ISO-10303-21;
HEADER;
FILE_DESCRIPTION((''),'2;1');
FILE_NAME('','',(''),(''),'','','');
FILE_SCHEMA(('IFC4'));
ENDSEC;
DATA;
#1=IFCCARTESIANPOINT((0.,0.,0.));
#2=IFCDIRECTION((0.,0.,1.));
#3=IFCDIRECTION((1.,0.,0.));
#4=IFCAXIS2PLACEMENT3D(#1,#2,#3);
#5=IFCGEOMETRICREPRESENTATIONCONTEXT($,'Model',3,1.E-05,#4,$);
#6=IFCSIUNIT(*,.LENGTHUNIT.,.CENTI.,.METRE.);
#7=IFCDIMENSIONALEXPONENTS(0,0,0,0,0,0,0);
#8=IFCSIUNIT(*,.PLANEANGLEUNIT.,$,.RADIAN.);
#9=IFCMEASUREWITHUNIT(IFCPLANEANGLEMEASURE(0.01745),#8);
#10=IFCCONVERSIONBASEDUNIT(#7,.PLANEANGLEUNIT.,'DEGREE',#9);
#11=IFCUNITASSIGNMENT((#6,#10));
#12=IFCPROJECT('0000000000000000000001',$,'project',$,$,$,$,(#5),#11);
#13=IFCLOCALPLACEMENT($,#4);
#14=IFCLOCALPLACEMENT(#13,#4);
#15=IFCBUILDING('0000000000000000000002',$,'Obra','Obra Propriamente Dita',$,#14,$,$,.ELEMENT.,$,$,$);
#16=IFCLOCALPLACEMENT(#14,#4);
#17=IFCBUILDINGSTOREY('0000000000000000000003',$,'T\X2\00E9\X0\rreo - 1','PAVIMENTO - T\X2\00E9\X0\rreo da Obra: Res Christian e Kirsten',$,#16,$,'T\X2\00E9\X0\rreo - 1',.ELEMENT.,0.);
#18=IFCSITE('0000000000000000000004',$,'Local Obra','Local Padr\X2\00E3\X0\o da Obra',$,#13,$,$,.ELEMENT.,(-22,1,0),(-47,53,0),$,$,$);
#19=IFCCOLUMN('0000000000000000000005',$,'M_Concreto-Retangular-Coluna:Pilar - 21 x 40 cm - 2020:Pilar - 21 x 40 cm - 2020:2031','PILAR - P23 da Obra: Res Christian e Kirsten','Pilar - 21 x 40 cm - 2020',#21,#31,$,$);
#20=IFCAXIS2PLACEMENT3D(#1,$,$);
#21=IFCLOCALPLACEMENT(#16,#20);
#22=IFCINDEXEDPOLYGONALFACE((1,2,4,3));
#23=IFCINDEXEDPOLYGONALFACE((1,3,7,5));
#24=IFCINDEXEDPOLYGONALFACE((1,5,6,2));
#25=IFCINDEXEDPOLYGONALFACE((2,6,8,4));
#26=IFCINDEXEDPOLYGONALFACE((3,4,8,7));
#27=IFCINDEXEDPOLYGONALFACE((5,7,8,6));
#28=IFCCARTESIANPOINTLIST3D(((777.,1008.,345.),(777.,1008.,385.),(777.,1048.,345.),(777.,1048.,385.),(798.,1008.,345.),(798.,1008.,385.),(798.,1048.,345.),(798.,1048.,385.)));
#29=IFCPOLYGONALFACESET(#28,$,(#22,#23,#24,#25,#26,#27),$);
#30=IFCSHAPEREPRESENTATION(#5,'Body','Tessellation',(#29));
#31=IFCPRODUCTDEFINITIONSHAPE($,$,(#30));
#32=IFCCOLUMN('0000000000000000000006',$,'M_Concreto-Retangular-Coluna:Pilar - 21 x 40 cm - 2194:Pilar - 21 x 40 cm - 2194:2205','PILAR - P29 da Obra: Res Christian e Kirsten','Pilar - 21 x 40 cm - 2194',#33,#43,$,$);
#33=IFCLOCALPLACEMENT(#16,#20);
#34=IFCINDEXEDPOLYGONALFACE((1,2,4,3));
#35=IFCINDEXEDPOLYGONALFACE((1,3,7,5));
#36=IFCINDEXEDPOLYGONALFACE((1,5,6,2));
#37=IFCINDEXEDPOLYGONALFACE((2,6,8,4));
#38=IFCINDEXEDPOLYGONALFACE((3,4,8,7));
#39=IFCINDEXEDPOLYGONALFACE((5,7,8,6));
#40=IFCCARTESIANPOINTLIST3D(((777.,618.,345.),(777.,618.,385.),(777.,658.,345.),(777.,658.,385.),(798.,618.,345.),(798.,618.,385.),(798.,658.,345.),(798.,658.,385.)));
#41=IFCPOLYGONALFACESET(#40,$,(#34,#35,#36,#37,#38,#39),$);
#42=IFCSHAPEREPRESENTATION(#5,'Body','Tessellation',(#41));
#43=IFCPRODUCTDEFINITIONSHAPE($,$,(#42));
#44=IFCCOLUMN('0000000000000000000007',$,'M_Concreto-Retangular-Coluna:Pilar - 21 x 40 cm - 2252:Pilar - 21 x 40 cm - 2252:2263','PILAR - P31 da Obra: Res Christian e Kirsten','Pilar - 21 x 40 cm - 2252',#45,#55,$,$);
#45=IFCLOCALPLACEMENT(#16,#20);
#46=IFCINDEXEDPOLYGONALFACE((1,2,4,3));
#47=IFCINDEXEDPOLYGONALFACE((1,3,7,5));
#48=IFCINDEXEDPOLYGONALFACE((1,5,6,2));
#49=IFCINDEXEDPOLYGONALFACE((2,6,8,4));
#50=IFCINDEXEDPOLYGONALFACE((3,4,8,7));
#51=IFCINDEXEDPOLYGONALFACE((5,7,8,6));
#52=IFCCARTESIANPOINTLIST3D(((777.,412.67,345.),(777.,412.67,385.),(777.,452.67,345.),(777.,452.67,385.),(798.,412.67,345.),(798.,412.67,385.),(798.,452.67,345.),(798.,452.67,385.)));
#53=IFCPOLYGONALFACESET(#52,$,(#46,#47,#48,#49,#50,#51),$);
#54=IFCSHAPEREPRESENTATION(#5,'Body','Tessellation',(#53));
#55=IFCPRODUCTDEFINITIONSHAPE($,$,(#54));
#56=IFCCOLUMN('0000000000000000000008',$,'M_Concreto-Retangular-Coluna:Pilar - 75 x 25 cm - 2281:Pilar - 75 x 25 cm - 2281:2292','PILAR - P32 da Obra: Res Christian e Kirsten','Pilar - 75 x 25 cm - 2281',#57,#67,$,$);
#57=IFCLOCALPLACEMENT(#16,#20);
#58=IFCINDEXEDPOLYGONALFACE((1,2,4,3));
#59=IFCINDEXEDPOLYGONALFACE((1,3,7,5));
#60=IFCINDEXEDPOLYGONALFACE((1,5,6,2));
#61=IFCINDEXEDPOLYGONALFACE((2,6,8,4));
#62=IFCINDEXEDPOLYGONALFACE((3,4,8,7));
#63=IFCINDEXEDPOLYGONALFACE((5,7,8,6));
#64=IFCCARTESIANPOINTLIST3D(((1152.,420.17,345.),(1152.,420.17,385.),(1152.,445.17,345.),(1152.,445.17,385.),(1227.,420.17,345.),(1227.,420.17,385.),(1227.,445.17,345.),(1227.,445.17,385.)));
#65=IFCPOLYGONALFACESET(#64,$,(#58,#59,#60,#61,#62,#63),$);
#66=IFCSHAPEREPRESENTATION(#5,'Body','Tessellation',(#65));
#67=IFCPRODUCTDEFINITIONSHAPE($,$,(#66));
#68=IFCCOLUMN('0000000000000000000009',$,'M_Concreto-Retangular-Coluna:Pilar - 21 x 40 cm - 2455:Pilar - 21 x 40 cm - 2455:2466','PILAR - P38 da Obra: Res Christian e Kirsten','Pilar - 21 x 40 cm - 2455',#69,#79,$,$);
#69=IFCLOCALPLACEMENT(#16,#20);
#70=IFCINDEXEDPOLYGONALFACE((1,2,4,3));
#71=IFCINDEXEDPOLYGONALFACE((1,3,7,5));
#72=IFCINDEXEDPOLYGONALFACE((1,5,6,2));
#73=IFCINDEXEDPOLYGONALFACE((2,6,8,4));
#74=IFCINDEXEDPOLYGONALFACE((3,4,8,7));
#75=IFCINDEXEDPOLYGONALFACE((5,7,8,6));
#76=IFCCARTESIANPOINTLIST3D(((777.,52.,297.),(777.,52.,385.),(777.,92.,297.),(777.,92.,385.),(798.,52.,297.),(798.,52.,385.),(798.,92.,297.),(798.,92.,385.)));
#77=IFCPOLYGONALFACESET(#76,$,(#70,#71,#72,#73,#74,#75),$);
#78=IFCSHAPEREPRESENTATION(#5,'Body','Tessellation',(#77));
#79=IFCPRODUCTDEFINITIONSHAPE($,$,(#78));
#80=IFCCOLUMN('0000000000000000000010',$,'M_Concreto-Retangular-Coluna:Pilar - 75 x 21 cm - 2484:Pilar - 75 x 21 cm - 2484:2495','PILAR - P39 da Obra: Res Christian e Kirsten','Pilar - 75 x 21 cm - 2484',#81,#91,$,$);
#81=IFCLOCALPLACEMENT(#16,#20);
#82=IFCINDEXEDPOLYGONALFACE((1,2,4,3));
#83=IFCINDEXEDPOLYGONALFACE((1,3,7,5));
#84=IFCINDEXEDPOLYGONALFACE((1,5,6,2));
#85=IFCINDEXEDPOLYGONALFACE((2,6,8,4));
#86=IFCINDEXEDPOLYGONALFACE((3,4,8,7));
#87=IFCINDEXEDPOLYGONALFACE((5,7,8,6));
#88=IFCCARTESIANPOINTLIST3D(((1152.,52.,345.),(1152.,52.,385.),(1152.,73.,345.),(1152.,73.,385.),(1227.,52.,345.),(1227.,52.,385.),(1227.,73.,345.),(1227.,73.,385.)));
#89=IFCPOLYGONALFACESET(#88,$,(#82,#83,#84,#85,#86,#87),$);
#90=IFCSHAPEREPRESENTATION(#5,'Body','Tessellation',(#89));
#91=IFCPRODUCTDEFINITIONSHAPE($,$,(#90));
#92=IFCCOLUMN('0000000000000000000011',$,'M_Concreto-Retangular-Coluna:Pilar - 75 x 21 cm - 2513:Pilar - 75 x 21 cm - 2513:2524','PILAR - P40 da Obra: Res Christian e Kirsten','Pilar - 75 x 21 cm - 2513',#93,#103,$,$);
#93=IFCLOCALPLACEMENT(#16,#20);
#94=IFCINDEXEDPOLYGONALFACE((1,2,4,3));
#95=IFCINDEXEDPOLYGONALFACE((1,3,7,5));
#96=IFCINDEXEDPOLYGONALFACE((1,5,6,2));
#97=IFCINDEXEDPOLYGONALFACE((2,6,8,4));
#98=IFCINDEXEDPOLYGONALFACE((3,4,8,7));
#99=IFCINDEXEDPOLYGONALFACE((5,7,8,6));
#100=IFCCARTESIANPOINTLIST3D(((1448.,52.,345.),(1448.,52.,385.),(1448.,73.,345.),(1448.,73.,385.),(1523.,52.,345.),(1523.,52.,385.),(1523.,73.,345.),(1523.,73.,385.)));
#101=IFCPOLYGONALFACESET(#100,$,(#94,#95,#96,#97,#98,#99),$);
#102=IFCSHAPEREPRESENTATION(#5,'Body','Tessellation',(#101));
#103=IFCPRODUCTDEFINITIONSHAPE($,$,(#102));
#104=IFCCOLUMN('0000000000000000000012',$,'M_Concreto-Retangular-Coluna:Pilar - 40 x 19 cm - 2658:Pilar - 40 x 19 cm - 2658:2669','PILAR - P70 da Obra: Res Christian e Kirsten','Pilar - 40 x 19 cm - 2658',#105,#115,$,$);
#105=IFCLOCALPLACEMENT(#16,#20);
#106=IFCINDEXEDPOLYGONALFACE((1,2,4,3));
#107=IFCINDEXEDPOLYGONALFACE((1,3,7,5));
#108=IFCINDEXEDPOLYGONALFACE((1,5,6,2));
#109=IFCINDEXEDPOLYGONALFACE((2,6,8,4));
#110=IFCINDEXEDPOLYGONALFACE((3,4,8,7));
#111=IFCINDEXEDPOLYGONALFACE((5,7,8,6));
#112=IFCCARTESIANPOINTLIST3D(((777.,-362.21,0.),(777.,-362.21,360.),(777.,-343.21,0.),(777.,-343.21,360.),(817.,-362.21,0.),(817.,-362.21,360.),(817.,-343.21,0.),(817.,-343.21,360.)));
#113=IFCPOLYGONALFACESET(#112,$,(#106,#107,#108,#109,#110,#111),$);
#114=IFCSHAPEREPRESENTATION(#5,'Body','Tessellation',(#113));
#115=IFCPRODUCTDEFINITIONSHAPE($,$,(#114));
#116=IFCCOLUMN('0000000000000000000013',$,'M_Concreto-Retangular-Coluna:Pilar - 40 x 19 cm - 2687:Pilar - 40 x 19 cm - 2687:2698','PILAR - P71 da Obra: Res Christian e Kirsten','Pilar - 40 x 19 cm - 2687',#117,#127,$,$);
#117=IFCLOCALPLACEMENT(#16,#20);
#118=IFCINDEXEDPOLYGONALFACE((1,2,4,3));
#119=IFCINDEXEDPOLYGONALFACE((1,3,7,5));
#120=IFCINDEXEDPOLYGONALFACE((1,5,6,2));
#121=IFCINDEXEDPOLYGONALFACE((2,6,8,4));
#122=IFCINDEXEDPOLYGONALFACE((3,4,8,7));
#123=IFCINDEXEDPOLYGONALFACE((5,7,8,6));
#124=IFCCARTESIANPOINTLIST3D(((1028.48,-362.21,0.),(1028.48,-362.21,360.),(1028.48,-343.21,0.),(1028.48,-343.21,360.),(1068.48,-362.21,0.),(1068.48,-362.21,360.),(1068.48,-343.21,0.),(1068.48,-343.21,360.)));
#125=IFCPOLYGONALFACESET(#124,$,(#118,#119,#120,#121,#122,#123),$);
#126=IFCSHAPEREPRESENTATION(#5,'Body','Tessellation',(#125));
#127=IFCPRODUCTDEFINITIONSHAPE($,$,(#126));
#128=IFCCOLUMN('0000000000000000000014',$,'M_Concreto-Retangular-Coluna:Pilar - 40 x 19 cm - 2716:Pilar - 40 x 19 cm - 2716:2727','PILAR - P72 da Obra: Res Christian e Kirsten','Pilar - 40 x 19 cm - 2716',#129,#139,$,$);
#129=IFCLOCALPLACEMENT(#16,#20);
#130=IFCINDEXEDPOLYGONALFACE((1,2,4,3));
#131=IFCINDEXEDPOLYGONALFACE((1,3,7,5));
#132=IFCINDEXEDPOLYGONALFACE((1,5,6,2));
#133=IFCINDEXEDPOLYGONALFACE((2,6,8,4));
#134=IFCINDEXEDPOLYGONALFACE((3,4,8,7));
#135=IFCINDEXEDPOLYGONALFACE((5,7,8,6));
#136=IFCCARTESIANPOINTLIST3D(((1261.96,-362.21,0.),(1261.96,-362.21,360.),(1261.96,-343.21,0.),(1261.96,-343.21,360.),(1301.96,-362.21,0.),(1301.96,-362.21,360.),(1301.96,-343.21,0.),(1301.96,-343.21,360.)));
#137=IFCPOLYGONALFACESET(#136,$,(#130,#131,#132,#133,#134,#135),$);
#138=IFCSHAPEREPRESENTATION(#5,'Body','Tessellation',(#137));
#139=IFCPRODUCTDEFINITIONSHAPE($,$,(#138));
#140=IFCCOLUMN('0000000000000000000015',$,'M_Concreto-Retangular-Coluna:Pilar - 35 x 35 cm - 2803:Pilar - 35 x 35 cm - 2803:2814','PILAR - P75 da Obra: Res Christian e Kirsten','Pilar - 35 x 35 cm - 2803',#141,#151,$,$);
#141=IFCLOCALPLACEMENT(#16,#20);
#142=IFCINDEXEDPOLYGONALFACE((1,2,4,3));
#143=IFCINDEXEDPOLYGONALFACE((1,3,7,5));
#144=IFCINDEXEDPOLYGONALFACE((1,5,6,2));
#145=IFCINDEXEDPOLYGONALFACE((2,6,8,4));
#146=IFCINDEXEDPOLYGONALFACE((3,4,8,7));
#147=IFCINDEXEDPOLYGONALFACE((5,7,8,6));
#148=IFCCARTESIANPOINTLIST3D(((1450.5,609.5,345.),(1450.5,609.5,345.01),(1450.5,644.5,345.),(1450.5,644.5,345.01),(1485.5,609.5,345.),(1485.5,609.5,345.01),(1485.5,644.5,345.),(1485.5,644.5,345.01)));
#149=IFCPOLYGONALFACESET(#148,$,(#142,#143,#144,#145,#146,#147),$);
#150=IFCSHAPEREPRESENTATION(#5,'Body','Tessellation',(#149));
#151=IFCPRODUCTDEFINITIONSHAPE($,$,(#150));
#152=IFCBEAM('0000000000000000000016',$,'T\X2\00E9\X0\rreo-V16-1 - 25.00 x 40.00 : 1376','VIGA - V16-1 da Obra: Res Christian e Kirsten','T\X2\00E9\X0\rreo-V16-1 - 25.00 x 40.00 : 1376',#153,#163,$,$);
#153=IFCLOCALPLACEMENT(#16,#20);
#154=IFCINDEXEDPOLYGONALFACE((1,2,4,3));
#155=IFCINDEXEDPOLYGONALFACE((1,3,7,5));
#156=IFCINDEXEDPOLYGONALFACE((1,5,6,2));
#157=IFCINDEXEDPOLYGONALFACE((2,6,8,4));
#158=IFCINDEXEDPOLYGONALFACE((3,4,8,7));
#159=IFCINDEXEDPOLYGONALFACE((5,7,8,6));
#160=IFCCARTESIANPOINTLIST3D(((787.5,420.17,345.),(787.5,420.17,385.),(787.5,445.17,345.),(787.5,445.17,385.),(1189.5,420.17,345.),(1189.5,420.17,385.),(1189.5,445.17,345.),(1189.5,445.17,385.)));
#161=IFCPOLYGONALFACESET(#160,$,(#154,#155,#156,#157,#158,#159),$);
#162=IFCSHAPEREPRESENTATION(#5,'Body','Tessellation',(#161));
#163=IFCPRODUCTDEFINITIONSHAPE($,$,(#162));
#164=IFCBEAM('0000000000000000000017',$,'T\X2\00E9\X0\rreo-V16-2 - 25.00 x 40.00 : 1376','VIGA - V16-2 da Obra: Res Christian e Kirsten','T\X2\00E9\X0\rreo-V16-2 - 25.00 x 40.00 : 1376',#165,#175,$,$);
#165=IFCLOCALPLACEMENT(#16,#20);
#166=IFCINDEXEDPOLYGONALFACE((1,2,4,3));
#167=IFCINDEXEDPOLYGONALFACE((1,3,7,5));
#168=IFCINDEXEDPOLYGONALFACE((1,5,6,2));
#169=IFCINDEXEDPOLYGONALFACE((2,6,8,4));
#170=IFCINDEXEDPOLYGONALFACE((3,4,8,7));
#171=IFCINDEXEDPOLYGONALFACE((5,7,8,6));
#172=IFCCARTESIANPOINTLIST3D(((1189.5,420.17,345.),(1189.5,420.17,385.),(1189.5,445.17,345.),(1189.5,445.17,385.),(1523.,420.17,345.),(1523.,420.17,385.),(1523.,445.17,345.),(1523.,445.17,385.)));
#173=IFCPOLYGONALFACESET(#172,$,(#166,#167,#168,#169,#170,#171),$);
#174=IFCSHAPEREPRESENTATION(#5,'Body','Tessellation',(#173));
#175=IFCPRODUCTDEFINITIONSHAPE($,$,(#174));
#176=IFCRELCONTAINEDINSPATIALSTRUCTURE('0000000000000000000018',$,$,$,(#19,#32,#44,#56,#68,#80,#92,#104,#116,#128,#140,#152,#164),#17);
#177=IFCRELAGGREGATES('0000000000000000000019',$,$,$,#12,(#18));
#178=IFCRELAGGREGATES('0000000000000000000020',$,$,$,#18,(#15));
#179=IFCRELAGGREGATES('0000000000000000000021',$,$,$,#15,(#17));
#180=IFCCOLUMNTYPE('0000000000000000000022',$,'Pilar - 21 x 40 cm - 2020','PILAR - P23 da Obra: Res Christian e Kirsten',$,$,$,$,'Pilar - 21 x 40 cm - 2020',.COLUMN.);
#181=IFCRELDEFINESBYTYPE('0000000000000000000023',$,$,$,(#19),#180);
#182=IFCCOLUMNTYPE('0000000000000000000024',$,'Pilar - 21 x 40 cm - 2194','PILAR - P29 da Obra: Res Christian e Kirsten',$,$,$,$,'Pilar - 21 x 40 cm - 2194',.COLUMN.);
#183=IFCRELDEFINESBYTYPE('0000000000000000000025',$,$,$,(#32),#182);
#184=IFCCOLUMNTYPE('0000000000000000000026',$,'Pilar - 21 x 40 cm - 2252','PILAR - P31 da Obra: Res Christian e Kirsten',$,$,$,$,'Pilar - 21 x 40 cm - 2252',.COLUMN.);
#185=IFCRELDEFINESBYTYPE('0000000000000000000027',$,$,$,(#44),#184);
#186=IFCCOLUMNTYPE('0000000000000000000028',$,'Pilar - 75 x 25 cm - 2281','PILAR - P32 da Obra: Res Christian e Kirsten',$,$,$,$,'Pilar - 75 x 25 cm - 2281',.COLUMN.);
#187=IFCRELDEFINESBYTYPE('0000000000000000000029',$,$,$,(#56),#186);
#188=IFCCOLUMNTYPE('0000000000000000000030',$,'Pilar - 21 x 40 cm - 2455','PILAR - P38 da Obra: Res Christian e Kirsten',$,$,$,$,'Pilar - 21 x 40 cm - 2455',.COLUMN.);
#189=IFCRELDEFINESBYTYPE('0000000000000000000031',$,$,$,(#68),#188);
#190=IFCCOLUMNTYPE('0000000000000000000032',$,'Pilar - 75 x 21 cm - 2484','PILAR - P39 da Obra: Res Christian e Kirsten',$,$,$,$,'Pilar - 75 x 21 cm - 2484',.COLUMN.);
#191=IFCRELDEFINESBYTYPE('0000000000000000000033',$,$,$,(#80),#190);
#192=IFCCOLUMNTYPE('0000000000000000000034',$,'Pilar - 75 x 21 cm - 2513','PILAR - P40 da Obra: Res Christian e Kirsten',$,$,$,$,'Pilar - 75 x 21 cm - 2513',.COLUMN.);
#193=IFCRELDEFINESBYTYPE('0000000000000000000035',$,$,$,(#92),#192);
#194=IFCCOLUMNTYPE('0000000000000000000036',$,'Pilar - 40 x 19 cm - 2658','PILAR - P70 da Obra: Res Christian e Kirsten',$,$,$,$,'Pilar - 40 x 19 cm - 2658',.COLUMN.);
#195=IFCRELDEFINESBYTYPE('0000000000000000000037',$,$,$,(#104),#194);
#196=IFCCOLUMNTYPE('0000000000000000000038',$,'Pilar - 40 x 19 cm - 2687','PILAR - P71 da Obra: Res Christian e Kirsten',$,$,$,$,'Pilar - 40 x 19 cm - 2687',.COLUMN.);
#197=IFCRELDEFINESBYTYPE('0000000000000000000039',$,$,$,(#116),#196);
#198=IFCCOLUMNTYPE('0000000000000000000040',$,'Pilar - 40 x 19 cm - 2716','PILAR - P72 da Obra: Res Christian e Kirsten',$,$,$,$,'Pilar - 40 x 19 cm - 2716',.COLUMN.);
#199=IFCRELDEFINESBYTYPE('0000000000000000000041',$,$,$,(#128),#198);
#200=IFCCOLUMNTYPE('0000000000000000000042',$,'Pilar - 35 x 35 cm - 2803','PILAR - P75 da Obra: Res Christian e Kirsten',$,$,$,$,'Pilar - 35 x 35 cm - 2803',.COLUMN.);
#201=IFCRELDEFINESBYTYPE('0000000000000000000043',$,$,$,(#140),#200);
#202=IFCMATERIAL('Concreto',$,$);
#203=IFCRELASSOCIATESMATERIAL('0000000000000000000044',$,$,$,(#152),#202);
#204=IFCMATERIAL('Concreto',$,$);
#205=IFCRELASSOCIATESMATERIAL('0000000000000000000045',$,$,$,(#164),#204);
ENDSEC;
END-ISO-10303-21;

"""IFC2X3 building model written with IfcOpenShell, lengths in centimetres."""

from ifc_helpers import new_model, entity, si_unit, converted_unit, frame, origin, origin_with_axes, origin_2d_with_axis, place, context, project, spatial, polyline, rectangle, outline, extrude, source, transform, mapped, material, type_object, type_shapes, element, save


model = new_model("IFC2X3")

# Units and contexts
model_context = context("Model", 3, precision=1e-05, world=origin_with_axes())
ifc_project = project(units=[si_unit("LENGTHUNIT", "METRE", prefix="CENTI"), converted_unit("PLANEANGLEUNIT", "DEGREE", entity("IfcPlaneAngleMeasure", 0.01745), si_unit("PLANEANGLEUNIT", "RADIAN"), dimensions=[0, 0, 0, 0, 0, 0, 0])], contexts=[model_context])

# Site, building, storey
site_placement = place(None, origin_with_axes())
site = spatial("IfcSite", under=ifc_project, at=site_placement, Name="Local Obra", Description="Local Padrão da Obra", CompositionType="ELEMENT", RefLatitude=(-22, 1, 0), RefLongitude=(-47, 53, 0))
building_placement = place(site_placement, origin_with_axes())
building = spatial("IfcBuilding", under=site, at=building_placement, Name="Obra", Description="Obra Propriamente Dita", CompositionType="ELEMENT")
storey_placement = place(building_placement, origin_with_axes())
storey = spatial("IfcBuildingStorey", under=building, at=storey_placement, Name="Térreo - 1", Description="PAVIMENTO - Térreo da Obra: Res Christian e Kirsten", LongName="Térreo - 1", CompositionType="ELEMENT", Elevation=0.0)

# Columns
column_type_1 = type_object("IfcColumnType", Name="Pilar - 21 x 40 cm - 2020", Description="PILAR - P23 da Obra: Res Christian e Kirsten", ElementType="Pilar - 21 x 40 cm - 2020", PredefinedType="COLUMN")
shared_shape_1 = source(origin(), model_context, "Body", "SweptSolid", [
    extrude(rectangle(XDim=21.0, YDim=40.0, at=origin_2d_with_axis()), origin(), (0.0, 0.0, 1.0), 40.0),
])
type_shapes(column_type_1, [shared_shape_1])
column_1_placement = place(storey_placement, frame((787.5, 1028.0, 345.0), z_axis=(0.0, 0.0, 1.0), x_axis=(1.0, 0.0, 0.0)))
element("IfcColumn", 1, at=column_1_placement, inside=storey, type_object=column_type_1, Name="M_Concreto-Retangular-Coluna:Pilar - 21 x 40 cm - 2020:Pilar - 21 x 40 cm - 2020:2031", Description="PILAR - P23 da Obra: Res Christian e Kirsten", ObjectType="Pilar - 21 x 40 cm - 2020", context=model_context, shape_type="MappedRepresentation", body=[
    mapped(shared_shape_1, transform((0.0, 0.0, 0.0), scale=1.0)),
])
column_type_2 = type_object("IfcColumnType", Name="Pilar - 21 x 40 cm - 2194", Description="PILAR - P29 da Obra: Res Christian e Kirsten", ElementType="Pilar - 21 x 40 cm - 2194", PredefinedType="COLUMN")
shared_shape_2 = source(origin(), model_context, "Body", "SweptSolid", [
    extrude(rectangle(XDim=21.0, YDim=40.0, at=origin_2d_with_axis()), origin(), (0.0, 0.0, 1.0), 40.0),
])
type_shapes(column_type_2, [shared_shape_2])
column_2_placement = place(storey_placement, frame((787.5, 638.0, 345.0), z_axis=(0.0, 0.0, 1.0), x_axis=(1.0, 0.0, 0.0)))
element("IfcColumn", 2, at=column_2_placement, inside=storey, type_object=column_type_2, Name="M_Concreto-Retangular-Coluna:Pilar - 21 x 40 cm - 2194:Pilar - 21 x 40 cm - 2194:2205", Description="PILAR - P29 da Obra: Res Christian e Kirsten", ObjectType="Pilar - 21 x 40 cm - 2194", context=model_context, shape_type="MappedRepresentation", body=[
    mapped(shared_shape_2, transform((0.0, 0.0, 0.0), scale=1.0)),
])
column_type_3 = type_object("IfcColumnType", Name="Pilar - 21 x 40 cm - 2252", Description="PILAR - P31 da Obra: Res Christian e Kirsten", ElementType="Pilar - 21 x 40 cm - 2252", PredefinedType="COLUMN")
shared_shape_3 = source(origin(), model_context, "Body", "SweptSolid", [
    extrude(rectangle(XDim=21.0, YDim=40.0, at=origin_2d_with_axis()), origin(), (0.0, 0.0, 1.0), 40.0),
])
type_shapes(column_type_3, [shared_shape_3])
column_3_placement = place(storey_placement, frame((787.5, 432.67, 345.0), z_axis=(0.0, 0.0, 1.0), x_axis=(1.0, 0.0, 0.0)))
element("IfcColumn", 3, at=column_3_placement, inside=storey, type_object=column_type_3, Name="M_Concreto-Retangular-Coluna:Pilar - 21 x 40 cm - 2252:Pilar - 21 x 40 cm - 2252:2263", Description="PILAR - P31 da Obra: Res Christian e Kirsten", ObjectType="Pilar - 21 x 40 cm - 2252", context=model_context, shape_type="MappedRepresentation", body=[
    mapped(shared_shape_3, transform((0.0, 0.0, 0.0), scale=1.0)),
])
column_type_4 = type_object("IfcColumnType", Name="Pilar - 75 x 25 cm - 2281", Description="PILAR - P32 da Obra: Res Christian e Kirsten", ElementType="Pilar - 75 x 25 cm - 2281", PredefinedType="COLUMN")
shared_shape_4 = source(origin(), model_context, "Body", "SweptSolid", [
    extrude(rectangle(XDim=75.0, YDim=25.0, at=origin_2d_with_axis()), origin(), (0.0, 0.0, 1.0), 40.0),
])
type_shapes(column_type_4, [shared_shape_4])
column_4_placement = place(storey_placement, frame((1189.5, 432.67, 345.0), z_axis=(0.0, 0.0, 1.0), x_axis=(1.0, 0.0, 0.0)))
element("IfcColumn", 4, at=column_4_placement, inside=storey, type_object=column_type_4, Name="M_Concreto-Retangular-Coluna:Pilar - 75 x 25 cm - 2281:Pilar - 75 x 25 cm - 2281:2292", Description="PILAR - P32 da Obra: Res Christian e Kirsten", ObjectType="Pilar - 75 x 25 cm - 2281", context=model_context, shape_type="MappedRepresentation", body=[
    mapped(shared_shape_4, transform((0.0, 0.0, 0.0), scale=1.0)),
])
column_type_5 = type_object("IfcColumnType", Name="Pilar - 21 x 40 cm - 2455", Description="PILAR - P38 da Obra: Res Christian e Kirsten", ElementType="Pilar - 21 x 40 cm - 2455", PredefinedType="COLUMN")
shared_shape_5 = source(origin(), model_context, "Body", "SweptSolid", [
    extrude(rectangle(XDim=21.0, YDim=40.0, at=origin_2d_with_axis()), origin(), (0.0, 0.0, 1.0), 88.0),
])
type_shapes(column_type_5, [shared_shape_5])
column_5_placement = place(storey_placement, frame((787.5, 72.0, 297.0), z_axis=(0.0, 0.0, 1.0), x_axis=(1.0, 0.0, 0.0)))
element("IfcColumn", 5, at=column_5_placement, inside=storey, type_object=column_type_5, Name="M_Concreto-Retangular-Coluna:Pilar - 21 x 40 cm - 2455:Pilar - 21 x 40 cm - 2455:2466", Description="PILAR - P38 da Obra: Res Christian e Kirsten", ObjectType="Pilar - 21 x 40 cm - 2455", context=model_context, shape_type="MappedRepresentation", body=[
    mapped(shared_shape_5, transform((0.0, 0.0, 0.0), scale=1.0)),
])
column_type_6 = type_object("IfcColumnType", Name="Pilar - 75 x 21 cm - 2484", Description="PILAR - P39 da Obra: Res Christian e Kirsten", ElementType="Pilar - 75 x 21 cm - 2484", PredefinedType="COLUMN")
shared_shape_6 = source(origin(), model_context, "Body", "SweptSolid", [
    extrude(rectangle(XDim=75.0, YDim=21.0, at=origin_2d_with_axis()), origin(), (0.0, 0.0, 1.0), 40.0),
])
type_shapes(column_type_6, [shared_shape_6])
column_6_placement = place(storey_placement, frame((1189.5, 62.5, 345.0), z_axis=(0.0, 0.0, 1.0), x_axis=(1.0, 0.0, 0.0)))
element("IfcColumn", 6, at=column_6_placement, inside=storey, type_object=column_type_6, Name="M_Concreto-Retangular-Coluna:Pilar - 75 x 21 cm - 2484:Pilar - 75 x 21 cm - 2484:2495", Description="PILAR - P39 da Obra: Res Christian e Kirsten", ObjectType="Pilar - 75 x 21 cm - 2484", context=model_context, shape_type="MappedRepresentation", body=[
    mapped(shared_shape_6, transform((0.0, 0.0, 0.0), scale=1.0)),
])
column_type_7 = type_object("IfcColumnType", Name="Pilar - 75 x 21 cm - 2513", Description="PILAR - P40 da Obra: Res Christian e Kirsten", ElementType="Pilar - 75 x 21 cm - 2513", PredefinedType="COLUMN")
shared_shape_7 = source(origin(), model_context, "Body", "SweptSolid", [
    extrude(rectangle(XDim=75.0, YDim=21.0, at=origin_2d_with_axis()), origin(), (0.0, 0.0, 1.0), 40.0),
])
type_shapes(column_type_7, [shared_shape_7])
column_7_placement = place(storey_placement, frame((1485.5, 62.5, 345.0), z_axis=(0.0, 0.0, 1.0), x_axis=(1.0, 0.0, 0.0)))
element("IfcColumn", 7, at=column_7_placement, inside=storey, type_object=column_type_7, Name="M_Concreto-Retangular-Coluna:Pilar - 75 x 21 cm - 2513:Pilar - 75 x 21 cm - 2513:2524", Description="PILAR - P40 da Obra: Res Christian e Kirsten", ObjectType="Pilar - 75 x 21 cm - 2513", context=model_context, shape_type="MappedRepresentation", body=[
    mapped(shared_shape_7, transform((0.0, 0.0, 0.0), scale=1.0)),
])
column_type_8 = type_object("IfcColumnType", Name="Pilar - 40 x 19 cm - 2658", Description="PILAR - P70 da Obra: Res Christian e Kirsten", ElementType="Pilar - 40 x 19 cm - 2658", PredefinedType="COLUMN")
shared_shape_8 = source(origin(), model_context, "Body", "SweptSolid", [
    extrude(rectangle(XDim=40.0, YDim=19.0, at=origin_2d_with_axis()), origin(), (0.0, 0.0, 1.0), 360.0),
])
type_shapes(column_type_8, [shared_shape_8])
column_8_placement = place(storey_placement, frame((797.0, -352.71, 0.0), z_axis=(0.0, 0.0, 1.0), x_axis=(1.0, 0.0, 0.0)))
element("IfcColumn", 8, at=column_8_placement, inside=storey, type_object=column_type_8, Name="M_Concreto-Retangular-Coluna:Pilar - 40 x 19 cm - 2658:Pilar - 40 x 19 cm - 2658:2669", Description="PILAR - P70 da Obra: Res Christian e Kirsten", ObjectType="Pilar - 40 x 19 cm - 2658", context=model_context, shape_type="MappedRepresentation", body=[
    mapped(shared_shape_8, transform((0.0, 0.0, 0.0), scale=1.0)),
])
column_type_9 = type_object("IfcColumnType", Name="Pilar - 40 x 19 cm - 2687", Description="PILAR - P71 da Obra: Res Christian e Kirsten", ElementType="Pilar - 40 x 19 cm - 2687", PredefinedType="COLUMN")
shared_shape_9 = source(origin(), model_context, "Body", "SweptSolid", [
    extrude(rectangle(XDim=40.0, YDim=19.0, at=origin_2d_with_axis()), origin(), (0.0, 0.0, 1.0), 360.0),
])
type_shapes(column_type_9, [shared_shape_9])
column_9_placement = place(storey_placement, frame((1048.48, -352.71, 0.0), z_axis=(0.0, 0.0, 1.0), x_axis=(1.0, 0.0, 0.0)))
element("IfcColumn", 9, at=column_9_placement, inside=storey, type_object=column_type_9, Name="M_Concreto-Retangular-Coluna:Pilar - 40 x 19 cm - 2687:Pilar - 40 x 19 cm - 2687:2698", Description="PILAR - P71 da Obra: Res Christian e Kirsten", ObjectType="Pilar - 40 x 19 cm - 2687", context=model_context, shape_type="MappedRepresentation", body=[
    mapped(shared_shape_9, transform((0.0, 0.0, 0.0), scale=1.0)),
])
column_type_10 = type_object("IfcColumnType", Name="Pilar - 40 x 19 cm - 2716", Description="PILAR - P72 da Obra: Res Christian e Kirsten", ElementType="Pilar - 40 x 19 cm - 2716", PredefinedType="COLUMN")
shared_shape_10 = source(origin(), model_context, "Body", "SweptSolid", [
    extrude(rectangle(XDim=40.0, YDim=19.0, at=origin_2d_with_axis()), origin(), (0.0, 0.0, 1.0), 360.0),
])
type_shapes(column_type_10, [shared_shape_10])
column_10_placement = place(storey_placement, frame((1281.96, -352.71, 0.0), z_axis=(0.0, 0.0, 1.0), x_axis=(1.0, 0.0, 0.0)))
element("IfcColumn", 10, at=column_10_placement, inside=storey, type_object=column_type_10, Name="M_Concreto-Retangular-Coluna:Pilar - 40 x 19 cm - 2716:Pilar - 40 x 19 cm - 2716:2727", Description="PILAR - P72 da Obra: Res Christian e Kirsten", ObjectType="Pilar - 40 x 19 cm - 2716", context=model_context, shape_type="MappedRepresentation", body=[
    mapped(shared_shape_10, transform((0.0, 0.0, 0.0), scale=1.0)),
])
column_type_11 = type_object("IfcColumnType", Name="Pilar - 35 x 35 cm - 2803", Description="PILAR - P75 da Obra: Res Christian e Kirsten", ElementType="Pilar - 35 x 35 cm - 2803", PredefinedType="COLUMN")
shared_shape_11 = source(origin(), model_context, "Body", "SweptSolid", [
    extrude(rectangle(XDim=35.0, YDim=35.0, at=origin_2d_with_axis()), origin(), (0.0, 0.0, 1.0), 0.01),
])
type_shapes(column_type_11, [shared_shape_11])
column_11_placement = place(storey_placement, frame((1468.0, 627.0, 345.0), z_axis=(0.0, 0.0, 1.0), x_axis=(1.0, 0.0, 0.0)))
element("IfcColumn", 11, at=column_11_placement, inside=storey, type_object=column_type_11, Name="M_Concreto-Retangular-Coluna:Pilar - 35 x 35 cm - 2803:Pilar - 35 x 35 cm - 2803:2814", Description="PILAR - P75 da Obra: Res Christian e Kirsten", ObjectType="Pilar - 35 x 35 cm - 2803", context=model_context, shape_type="MappedRepresentation", body=[
    mapped(shared_shape_11, transform((0.0, 0.0, 0.0), scale=1.0)),
])

# Beams
ifc_material_1 = material(Name="Concreto")
beam_1_placement = place(storey_placement, frame((787.5, 432.67, 385.0), z_axis=(1.0, 0.0, 0.0), x_axis=(0.0, -1.0, 0.0)))
element("IfcBeam", 12, at=beam_1_placement, inside=storey, material=ifc_material_1, Name="Térreo-V16-1 - 25.00 x 40.00 : 1376", Description="VIGA - V16-1 da Obra: Res Christian e Kirsten", ObjectType="Térreo-V16-1 - 25.00 x 40.00 : 1376", context=model_context, shape_type="SweptSolid", body=[
    extrude(outline(polyline([(-12.5, 0.0), (12.5, 0.0), (12.5, 40.0), (-12.5, 40.0), (-12.5, 0.0)])), origin_with_axes(), (0.0, 0.0, 1.0), 402.0),
])
ifc_material_2 = material(Name="Concreto")
beam_2_placement = place(storey_placement, frame((1189.5, 432.67, 385.0), z_axis=(1.0, 0.0, 0.0), x_axis=(0.0, -1.0, 0.0)))
element("IfcBeam", 13, at=beam_2_placement, inside=storey, material=ifc_material_2, Name="Térreo-V16-2 - 25.00 x 40.00 : 1376", Description="VIGA - V16-2 da Obra: Res Christian e Kirsten", ObjectType="Térreo-V16-2 - 25.00 x 40.00 : 1376", context=model_context, shape_type="SweptSolid", body=[
    extrude(outline(polyline([(-12.5, 0.0), (12.5, 0.0), (12.5, 40.0), (-12.5, 40.0), (-12.5, 0.0)])), origin_with_axes(), (0.0, 0.0, 1.0), 333.5),
])

save(model, "model.ifc")
